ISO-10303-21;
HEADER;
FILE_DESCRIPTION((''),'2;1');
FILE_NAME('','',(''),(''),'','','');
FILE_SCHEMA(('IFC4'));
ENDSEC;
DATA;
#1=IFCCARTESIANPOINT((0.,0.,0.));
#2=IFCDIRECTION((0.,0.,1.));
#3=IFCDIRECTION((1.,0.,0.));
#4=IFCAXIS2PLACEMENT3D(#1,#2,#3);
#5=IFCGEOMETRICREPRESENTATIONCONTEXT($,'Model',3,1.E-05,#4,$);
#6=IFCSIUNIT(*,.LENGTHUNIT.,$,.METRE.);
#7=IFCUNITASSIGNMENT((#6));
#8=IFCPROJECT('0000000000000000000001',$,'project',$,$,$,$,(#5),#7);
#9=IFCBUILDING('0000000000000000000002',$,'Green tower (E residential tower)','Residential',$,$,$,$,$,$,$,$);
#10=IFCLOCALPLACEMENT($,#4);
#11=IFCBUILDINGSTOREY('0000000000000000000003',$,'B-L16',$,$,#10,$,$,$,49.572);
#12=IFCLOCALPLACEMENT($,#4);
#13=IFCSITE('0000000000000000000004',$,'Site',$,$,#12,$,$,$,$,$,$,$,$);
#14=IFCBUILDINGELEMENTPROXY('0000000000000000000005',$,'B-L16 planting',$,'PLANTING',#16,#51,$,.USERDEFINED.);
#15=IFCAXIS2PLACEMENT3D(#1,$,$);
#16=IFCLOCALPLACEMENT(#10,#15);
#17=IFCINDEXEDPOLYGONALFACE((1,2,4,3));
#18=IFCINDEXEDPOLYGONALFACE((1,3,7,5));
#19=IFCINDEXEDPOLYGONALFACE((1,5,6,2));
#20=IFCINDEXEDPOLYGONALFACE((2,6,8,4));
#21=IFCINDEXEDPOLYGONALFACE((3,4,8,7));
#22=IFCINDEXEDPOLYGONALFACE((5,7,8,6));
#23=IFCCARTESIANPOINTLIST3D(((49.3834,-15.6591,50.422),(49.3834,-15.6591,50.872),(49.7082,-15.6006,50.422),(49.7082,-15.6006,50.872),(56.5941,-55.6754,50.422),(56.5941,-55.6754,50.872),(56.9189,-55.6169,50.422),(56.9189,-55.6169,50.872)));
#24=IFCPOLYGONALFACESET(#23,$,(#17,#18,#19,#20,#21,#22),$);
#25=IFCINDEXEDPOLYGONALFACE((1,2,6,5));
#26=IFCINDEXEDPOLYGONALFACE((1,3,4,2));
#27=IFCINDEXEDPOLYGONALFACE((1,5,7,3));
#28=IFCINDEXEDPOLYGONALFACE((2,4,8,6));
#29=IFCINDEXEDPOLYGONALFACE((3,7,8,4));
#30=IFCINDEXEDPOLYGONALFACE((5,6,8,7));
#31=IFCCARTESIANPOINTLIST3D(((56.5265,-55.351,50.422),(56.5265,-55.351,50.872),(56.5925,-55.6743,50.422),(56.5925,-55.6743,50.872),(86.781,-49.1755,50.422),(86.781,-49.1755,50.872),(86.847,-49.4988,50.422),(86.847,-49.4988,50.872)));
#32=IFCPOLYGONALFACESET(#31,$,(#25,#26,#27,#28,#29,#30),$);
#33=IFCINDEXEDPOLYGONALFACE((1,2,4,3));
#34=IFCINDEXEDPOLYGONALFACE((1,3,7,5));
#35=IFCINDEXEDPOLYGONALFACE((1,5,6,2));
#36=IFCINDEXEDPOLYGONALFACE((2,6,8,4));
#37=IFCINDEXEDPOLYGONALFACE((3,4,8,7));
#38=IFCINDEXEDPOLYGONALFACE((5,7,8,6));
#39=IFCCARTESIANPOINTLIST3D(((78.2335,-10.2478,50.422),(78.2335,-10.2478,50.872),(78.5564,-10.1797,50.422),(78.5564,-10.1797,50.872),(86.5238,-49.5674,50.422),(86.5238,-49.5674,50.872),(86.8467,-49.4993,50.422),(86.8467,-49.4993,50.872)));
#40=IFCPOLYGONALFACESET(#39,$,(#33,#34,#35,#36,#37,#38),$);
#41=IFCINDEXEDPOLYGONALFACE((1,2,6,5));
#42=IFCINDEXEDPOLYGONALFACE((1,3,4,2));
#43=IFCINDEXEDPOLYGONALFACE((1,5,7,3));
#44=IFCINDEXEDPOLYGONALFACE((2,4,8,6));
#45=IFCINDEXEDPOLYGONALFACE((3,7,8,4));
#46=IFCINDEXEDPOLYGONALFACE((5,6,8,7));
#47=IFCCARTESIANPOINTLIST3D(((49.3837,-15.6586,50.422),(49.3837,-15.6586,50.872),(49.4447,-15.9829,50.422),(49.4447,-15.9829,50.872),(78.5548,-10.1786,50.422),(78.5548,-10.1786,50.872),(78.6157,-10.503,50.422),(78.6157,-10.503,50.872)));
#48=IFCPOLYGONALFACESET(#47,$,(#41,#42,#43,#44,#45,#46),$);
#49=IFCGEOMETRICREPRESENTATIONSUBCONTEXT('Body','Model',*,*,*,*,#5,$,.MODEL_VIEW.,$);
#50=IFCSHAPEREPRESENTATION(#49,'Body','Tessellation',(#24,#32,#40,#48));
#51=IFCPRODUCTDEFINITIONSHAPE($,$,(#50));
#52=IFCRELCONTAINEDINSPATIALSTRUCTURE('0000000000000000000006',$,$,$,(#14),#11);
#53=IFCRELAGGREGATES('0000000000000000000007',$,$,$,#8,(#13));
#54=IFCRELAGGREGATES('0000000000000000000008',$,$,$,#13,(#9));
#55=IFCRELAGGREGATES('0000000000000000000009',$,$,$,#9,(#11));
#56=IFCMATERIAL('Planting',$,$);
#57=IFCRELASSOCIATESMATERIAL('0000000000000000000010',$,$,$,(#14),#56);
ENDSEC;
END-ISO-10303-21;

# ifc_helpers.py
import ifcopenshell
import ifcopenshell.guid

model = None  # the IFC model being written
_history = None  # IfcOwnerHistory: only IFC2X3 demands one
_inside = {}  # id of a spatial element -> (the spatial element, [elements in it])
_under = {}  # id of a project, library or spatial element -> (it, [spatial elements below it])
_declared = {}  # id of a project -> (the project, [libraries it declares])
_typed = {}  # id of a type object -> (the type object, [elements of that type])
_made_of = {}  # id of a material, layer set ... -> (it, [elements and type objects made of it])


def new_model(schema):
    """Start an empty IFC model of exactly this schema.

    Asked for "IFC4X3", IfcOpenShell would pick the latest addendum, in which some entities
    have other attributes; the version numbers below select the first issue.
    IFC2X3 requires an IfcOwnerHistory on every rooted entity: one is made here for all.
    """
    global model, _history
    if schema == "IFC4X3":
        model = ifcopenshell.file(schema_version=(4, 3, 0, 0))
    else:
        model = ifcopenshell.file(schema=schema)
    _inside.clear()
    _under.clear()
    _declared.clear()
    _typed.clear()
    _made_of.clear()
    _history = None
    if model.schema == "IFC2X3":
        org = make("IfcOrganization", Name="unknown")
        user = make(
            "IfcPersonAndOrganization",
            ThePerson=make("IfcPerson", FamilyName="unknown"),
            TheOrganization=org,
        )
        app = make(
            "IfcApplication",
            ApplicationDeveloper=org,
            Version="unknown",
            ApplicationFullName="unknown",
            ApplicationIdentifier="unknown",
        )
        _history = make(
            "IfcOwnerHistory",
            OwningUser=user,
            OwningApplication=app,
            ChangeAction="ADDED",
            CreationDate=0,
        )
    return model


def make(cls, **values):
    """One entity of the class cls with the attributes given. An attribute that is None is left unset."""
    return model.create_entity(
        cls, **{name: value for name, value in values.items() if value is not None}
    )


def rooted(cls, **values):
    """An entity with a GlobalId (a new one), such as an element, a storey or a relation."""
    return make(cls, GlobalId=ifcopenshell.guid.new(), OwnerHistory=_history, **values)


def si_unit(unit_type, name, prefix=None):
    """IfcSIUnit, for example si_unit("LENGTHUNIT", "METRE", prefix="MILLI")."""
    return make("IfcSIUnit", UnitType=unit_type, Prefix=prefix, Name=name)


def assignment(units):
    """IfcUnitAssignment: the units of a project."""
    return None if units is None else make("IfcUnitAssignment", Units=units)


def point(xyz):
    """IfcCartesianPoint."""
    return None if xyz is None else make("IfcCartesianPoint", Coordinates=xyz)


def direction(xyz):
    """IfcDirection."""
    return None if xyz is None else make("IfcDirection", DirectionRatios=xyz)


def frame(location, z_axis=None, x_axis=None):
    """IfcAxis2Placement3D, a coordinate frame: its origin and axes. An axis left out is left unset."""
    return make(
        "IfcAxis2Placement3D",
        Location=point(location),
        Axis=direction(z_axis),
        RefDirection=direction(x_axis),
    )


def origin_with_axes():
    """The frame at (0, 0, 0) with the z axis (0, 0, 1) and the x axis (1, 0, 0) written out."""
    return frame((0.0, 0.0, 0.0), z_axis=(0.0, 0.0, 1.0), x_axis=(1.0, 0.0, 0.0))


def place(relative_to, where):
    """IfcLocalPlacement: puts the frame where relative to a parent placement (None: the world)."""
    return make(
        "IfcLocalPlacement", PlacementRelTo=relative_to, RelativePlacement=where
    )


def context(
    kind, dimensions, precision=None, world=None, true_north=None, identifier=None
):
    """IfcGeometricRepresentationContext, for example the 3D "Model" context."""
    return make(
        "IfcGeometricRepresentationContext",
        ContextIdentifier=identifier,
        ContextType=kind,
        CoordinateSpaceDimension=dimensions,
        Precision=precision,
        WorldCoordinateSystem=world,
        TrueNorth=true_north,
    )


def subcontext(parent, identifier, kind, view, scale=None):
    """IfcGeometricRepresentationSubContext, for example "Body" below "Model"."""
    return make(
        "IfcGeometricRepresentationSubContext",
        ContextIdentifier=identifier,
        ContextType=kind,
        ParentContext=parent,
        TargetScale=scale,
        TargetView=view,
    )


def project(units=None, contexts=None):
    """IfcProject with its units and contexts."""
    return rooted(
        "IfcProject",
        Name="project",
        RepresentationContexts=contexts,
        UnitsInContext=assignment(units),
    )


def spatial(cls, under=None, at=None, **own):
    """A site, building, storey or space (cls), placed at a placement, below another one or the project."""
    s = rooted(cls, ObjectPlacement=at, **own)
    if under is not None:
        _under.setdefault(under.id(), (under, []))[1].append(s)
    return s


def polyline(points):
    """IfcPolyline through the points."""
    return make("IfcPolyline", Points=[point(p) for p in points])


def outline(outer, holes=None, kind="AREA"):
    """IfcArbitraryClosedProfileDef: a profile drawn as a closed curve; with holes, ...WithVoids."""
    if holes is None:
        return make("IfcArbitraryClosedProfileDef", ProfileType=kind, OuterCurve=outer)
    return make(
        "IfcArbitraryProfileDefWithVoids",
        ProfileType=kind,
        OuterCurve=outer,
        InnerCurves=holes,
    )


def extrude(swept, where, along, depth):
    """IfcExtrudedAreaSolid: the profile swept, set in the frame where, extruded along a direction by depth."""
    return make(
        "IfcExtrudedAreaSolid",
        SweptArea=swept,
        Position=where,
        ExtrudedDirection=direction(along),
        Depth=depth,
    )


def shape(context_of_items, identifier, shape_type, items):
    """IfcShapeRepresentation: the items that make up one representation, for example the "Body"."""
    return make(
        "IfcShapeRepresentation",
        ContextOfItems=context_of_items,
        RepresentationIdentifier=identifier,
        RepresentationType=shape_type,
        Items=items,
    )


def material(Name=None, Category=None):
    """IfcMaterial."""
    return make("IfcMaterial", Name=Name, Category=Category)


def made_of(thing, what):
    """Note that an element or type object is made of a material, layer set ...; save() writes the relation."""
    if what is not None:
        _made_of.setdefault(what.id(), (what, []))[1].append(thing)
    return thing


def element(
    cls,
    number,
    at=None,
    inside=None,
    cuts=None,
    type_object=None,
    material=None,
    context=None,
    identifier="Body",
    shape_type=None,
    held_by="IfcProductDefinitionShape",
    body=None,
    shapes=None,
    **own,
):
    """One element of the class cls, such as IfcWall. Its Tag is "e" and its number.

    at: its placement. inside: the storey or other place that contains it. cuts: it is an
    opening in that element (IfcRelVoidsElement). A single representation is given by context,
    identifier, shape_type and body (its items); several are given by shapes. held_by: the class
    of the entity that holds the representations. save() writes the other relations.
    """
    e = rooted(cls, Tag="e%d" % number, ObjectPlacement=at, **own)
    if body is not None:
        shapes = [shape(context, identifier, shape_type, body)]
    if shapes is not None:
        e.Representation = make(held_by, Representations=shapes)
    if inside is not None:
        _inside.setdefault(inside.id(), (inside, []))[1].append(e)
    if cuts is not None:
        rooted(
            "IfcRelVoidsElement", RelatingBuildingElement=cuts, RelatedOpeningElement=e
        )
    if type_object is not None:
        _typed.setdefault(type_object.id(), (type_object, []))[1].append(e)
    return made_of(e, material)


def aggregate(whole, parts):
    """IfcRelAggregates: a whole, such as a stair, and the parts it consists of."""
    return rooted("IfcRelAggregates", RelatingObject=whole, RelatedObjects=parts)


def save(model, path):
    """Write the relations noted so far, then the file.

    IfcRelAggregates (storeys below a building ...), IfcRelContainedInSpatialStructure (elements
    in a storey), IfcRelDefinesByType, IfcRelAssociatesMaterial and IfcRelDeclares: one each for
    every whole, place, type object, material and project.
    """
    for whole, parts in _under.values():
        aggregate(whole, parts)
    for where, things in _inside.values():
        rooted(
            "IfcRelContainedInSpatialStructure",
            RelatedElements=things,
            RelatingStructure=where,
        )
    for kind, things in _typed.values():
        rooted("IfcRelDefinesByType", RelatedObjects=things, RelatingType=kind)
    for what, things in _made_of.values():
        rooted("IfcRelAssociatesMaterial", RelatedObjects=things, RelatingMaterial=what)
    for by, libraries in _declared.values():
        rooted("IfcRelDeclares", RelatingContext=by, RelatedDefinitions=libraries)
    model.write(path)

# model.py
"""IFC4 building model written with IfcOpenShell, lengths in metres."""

from ifc_helpers import new_model, si_unit, frame, origin_with_axes, place, context, subcontext, project, spatial, polyline, outline, extrude, material, element, save


model = new_model("IFC4")

# Units and contexts
model_context = context("Model", 3, precision=1e-05, world=origin_with_axes())
body_context = subcontext(model_context, "Body", "Model", "MODEL_VIEW")
ifc_project = project(units=[si_unit("LENGTHUNIT", "METRE")], contexts=[model_context])

# Site, building, storey
site_placement = place(None, origin_with_axes())
site = spatial("IfcSite", under=ifc_project, at=site_placement, Name="Site")
building = spatial("IfcBuilding", under=site, Name="Green tower (E residential tower)", Description="Residential")
storey_placement = place(None, origin_with_axes())
storey = spatial("IfcBuildingStorey", under=building, at=storey_placement, Name="B-L16", Elevation=49.572)

# Building element proxy
ifc_material_1 = material(Name="Planting")
proxy_1_placement = place(storey_placement, origin_with_axes())
element("IfcBuildingElementProxy", 1, at=proxy_1_placement, inside=storey, material=ifc_material_1, Name="B-L16 planting", ObjectType="PLANTING", PredefinedType="USERDEFINED", context=body_context, shape_type="SweptSolid", body=[
    extrude(outline(polyline([(49.3834, -15.6591), (56.5941, -55.6754), (56.9189, -55.6169), (49.7082, -15.6006), (49.3834, -15.6591)])), frame((0.0, 0.0, 50.422), z_axis=(0.0, 0.0, 1.0), x_axis=(1.0, 0.0, 0.0)), (0.0, 0.0, 1.0), 0.45),
    extrude(outline(polyline([(56.5925, -55.6743), (86.847, -49.4988), (86.781, -49.1755), (56.5265, -55.351), (56.5925, -55.6743)])), frame((0.0, 0.0, 50.422), z_axis=(0.0, 0.0, 1.0), x_axis=(1.0, 0.0, 0.0)), (0.0, 0.0, 1.0), 0.45),
    extrude(outline(polyline([(86.8467, -49.4993), (78.5564, -10.1797), (78.2335, -10.2478), (86.5238, -49.5674), (86.8467, -49.4993)])), frame((0.0, 0.0, 50.422), z_axis=(0.0, 0.0, 1.0), x_axis=(1.0, 0.0, 0.0)), (0.0, 0.0, 1.0), 0.45),
    extrude(outline(polyline([(78.5548, -10.1786), (49.3837, -15.6586), (49.4447, -15.9829), (78.6157, -10.503), (78.5548, -10.1786)])), frame((0.0, 0.0, 50.422), z_axis=(0.0, 0.0, 1.0), x_axis=(1.0, 0.0, 0.0)), (0.0, 0.0, 1.0), 0.45),
])

save(model, "model.ifc")
